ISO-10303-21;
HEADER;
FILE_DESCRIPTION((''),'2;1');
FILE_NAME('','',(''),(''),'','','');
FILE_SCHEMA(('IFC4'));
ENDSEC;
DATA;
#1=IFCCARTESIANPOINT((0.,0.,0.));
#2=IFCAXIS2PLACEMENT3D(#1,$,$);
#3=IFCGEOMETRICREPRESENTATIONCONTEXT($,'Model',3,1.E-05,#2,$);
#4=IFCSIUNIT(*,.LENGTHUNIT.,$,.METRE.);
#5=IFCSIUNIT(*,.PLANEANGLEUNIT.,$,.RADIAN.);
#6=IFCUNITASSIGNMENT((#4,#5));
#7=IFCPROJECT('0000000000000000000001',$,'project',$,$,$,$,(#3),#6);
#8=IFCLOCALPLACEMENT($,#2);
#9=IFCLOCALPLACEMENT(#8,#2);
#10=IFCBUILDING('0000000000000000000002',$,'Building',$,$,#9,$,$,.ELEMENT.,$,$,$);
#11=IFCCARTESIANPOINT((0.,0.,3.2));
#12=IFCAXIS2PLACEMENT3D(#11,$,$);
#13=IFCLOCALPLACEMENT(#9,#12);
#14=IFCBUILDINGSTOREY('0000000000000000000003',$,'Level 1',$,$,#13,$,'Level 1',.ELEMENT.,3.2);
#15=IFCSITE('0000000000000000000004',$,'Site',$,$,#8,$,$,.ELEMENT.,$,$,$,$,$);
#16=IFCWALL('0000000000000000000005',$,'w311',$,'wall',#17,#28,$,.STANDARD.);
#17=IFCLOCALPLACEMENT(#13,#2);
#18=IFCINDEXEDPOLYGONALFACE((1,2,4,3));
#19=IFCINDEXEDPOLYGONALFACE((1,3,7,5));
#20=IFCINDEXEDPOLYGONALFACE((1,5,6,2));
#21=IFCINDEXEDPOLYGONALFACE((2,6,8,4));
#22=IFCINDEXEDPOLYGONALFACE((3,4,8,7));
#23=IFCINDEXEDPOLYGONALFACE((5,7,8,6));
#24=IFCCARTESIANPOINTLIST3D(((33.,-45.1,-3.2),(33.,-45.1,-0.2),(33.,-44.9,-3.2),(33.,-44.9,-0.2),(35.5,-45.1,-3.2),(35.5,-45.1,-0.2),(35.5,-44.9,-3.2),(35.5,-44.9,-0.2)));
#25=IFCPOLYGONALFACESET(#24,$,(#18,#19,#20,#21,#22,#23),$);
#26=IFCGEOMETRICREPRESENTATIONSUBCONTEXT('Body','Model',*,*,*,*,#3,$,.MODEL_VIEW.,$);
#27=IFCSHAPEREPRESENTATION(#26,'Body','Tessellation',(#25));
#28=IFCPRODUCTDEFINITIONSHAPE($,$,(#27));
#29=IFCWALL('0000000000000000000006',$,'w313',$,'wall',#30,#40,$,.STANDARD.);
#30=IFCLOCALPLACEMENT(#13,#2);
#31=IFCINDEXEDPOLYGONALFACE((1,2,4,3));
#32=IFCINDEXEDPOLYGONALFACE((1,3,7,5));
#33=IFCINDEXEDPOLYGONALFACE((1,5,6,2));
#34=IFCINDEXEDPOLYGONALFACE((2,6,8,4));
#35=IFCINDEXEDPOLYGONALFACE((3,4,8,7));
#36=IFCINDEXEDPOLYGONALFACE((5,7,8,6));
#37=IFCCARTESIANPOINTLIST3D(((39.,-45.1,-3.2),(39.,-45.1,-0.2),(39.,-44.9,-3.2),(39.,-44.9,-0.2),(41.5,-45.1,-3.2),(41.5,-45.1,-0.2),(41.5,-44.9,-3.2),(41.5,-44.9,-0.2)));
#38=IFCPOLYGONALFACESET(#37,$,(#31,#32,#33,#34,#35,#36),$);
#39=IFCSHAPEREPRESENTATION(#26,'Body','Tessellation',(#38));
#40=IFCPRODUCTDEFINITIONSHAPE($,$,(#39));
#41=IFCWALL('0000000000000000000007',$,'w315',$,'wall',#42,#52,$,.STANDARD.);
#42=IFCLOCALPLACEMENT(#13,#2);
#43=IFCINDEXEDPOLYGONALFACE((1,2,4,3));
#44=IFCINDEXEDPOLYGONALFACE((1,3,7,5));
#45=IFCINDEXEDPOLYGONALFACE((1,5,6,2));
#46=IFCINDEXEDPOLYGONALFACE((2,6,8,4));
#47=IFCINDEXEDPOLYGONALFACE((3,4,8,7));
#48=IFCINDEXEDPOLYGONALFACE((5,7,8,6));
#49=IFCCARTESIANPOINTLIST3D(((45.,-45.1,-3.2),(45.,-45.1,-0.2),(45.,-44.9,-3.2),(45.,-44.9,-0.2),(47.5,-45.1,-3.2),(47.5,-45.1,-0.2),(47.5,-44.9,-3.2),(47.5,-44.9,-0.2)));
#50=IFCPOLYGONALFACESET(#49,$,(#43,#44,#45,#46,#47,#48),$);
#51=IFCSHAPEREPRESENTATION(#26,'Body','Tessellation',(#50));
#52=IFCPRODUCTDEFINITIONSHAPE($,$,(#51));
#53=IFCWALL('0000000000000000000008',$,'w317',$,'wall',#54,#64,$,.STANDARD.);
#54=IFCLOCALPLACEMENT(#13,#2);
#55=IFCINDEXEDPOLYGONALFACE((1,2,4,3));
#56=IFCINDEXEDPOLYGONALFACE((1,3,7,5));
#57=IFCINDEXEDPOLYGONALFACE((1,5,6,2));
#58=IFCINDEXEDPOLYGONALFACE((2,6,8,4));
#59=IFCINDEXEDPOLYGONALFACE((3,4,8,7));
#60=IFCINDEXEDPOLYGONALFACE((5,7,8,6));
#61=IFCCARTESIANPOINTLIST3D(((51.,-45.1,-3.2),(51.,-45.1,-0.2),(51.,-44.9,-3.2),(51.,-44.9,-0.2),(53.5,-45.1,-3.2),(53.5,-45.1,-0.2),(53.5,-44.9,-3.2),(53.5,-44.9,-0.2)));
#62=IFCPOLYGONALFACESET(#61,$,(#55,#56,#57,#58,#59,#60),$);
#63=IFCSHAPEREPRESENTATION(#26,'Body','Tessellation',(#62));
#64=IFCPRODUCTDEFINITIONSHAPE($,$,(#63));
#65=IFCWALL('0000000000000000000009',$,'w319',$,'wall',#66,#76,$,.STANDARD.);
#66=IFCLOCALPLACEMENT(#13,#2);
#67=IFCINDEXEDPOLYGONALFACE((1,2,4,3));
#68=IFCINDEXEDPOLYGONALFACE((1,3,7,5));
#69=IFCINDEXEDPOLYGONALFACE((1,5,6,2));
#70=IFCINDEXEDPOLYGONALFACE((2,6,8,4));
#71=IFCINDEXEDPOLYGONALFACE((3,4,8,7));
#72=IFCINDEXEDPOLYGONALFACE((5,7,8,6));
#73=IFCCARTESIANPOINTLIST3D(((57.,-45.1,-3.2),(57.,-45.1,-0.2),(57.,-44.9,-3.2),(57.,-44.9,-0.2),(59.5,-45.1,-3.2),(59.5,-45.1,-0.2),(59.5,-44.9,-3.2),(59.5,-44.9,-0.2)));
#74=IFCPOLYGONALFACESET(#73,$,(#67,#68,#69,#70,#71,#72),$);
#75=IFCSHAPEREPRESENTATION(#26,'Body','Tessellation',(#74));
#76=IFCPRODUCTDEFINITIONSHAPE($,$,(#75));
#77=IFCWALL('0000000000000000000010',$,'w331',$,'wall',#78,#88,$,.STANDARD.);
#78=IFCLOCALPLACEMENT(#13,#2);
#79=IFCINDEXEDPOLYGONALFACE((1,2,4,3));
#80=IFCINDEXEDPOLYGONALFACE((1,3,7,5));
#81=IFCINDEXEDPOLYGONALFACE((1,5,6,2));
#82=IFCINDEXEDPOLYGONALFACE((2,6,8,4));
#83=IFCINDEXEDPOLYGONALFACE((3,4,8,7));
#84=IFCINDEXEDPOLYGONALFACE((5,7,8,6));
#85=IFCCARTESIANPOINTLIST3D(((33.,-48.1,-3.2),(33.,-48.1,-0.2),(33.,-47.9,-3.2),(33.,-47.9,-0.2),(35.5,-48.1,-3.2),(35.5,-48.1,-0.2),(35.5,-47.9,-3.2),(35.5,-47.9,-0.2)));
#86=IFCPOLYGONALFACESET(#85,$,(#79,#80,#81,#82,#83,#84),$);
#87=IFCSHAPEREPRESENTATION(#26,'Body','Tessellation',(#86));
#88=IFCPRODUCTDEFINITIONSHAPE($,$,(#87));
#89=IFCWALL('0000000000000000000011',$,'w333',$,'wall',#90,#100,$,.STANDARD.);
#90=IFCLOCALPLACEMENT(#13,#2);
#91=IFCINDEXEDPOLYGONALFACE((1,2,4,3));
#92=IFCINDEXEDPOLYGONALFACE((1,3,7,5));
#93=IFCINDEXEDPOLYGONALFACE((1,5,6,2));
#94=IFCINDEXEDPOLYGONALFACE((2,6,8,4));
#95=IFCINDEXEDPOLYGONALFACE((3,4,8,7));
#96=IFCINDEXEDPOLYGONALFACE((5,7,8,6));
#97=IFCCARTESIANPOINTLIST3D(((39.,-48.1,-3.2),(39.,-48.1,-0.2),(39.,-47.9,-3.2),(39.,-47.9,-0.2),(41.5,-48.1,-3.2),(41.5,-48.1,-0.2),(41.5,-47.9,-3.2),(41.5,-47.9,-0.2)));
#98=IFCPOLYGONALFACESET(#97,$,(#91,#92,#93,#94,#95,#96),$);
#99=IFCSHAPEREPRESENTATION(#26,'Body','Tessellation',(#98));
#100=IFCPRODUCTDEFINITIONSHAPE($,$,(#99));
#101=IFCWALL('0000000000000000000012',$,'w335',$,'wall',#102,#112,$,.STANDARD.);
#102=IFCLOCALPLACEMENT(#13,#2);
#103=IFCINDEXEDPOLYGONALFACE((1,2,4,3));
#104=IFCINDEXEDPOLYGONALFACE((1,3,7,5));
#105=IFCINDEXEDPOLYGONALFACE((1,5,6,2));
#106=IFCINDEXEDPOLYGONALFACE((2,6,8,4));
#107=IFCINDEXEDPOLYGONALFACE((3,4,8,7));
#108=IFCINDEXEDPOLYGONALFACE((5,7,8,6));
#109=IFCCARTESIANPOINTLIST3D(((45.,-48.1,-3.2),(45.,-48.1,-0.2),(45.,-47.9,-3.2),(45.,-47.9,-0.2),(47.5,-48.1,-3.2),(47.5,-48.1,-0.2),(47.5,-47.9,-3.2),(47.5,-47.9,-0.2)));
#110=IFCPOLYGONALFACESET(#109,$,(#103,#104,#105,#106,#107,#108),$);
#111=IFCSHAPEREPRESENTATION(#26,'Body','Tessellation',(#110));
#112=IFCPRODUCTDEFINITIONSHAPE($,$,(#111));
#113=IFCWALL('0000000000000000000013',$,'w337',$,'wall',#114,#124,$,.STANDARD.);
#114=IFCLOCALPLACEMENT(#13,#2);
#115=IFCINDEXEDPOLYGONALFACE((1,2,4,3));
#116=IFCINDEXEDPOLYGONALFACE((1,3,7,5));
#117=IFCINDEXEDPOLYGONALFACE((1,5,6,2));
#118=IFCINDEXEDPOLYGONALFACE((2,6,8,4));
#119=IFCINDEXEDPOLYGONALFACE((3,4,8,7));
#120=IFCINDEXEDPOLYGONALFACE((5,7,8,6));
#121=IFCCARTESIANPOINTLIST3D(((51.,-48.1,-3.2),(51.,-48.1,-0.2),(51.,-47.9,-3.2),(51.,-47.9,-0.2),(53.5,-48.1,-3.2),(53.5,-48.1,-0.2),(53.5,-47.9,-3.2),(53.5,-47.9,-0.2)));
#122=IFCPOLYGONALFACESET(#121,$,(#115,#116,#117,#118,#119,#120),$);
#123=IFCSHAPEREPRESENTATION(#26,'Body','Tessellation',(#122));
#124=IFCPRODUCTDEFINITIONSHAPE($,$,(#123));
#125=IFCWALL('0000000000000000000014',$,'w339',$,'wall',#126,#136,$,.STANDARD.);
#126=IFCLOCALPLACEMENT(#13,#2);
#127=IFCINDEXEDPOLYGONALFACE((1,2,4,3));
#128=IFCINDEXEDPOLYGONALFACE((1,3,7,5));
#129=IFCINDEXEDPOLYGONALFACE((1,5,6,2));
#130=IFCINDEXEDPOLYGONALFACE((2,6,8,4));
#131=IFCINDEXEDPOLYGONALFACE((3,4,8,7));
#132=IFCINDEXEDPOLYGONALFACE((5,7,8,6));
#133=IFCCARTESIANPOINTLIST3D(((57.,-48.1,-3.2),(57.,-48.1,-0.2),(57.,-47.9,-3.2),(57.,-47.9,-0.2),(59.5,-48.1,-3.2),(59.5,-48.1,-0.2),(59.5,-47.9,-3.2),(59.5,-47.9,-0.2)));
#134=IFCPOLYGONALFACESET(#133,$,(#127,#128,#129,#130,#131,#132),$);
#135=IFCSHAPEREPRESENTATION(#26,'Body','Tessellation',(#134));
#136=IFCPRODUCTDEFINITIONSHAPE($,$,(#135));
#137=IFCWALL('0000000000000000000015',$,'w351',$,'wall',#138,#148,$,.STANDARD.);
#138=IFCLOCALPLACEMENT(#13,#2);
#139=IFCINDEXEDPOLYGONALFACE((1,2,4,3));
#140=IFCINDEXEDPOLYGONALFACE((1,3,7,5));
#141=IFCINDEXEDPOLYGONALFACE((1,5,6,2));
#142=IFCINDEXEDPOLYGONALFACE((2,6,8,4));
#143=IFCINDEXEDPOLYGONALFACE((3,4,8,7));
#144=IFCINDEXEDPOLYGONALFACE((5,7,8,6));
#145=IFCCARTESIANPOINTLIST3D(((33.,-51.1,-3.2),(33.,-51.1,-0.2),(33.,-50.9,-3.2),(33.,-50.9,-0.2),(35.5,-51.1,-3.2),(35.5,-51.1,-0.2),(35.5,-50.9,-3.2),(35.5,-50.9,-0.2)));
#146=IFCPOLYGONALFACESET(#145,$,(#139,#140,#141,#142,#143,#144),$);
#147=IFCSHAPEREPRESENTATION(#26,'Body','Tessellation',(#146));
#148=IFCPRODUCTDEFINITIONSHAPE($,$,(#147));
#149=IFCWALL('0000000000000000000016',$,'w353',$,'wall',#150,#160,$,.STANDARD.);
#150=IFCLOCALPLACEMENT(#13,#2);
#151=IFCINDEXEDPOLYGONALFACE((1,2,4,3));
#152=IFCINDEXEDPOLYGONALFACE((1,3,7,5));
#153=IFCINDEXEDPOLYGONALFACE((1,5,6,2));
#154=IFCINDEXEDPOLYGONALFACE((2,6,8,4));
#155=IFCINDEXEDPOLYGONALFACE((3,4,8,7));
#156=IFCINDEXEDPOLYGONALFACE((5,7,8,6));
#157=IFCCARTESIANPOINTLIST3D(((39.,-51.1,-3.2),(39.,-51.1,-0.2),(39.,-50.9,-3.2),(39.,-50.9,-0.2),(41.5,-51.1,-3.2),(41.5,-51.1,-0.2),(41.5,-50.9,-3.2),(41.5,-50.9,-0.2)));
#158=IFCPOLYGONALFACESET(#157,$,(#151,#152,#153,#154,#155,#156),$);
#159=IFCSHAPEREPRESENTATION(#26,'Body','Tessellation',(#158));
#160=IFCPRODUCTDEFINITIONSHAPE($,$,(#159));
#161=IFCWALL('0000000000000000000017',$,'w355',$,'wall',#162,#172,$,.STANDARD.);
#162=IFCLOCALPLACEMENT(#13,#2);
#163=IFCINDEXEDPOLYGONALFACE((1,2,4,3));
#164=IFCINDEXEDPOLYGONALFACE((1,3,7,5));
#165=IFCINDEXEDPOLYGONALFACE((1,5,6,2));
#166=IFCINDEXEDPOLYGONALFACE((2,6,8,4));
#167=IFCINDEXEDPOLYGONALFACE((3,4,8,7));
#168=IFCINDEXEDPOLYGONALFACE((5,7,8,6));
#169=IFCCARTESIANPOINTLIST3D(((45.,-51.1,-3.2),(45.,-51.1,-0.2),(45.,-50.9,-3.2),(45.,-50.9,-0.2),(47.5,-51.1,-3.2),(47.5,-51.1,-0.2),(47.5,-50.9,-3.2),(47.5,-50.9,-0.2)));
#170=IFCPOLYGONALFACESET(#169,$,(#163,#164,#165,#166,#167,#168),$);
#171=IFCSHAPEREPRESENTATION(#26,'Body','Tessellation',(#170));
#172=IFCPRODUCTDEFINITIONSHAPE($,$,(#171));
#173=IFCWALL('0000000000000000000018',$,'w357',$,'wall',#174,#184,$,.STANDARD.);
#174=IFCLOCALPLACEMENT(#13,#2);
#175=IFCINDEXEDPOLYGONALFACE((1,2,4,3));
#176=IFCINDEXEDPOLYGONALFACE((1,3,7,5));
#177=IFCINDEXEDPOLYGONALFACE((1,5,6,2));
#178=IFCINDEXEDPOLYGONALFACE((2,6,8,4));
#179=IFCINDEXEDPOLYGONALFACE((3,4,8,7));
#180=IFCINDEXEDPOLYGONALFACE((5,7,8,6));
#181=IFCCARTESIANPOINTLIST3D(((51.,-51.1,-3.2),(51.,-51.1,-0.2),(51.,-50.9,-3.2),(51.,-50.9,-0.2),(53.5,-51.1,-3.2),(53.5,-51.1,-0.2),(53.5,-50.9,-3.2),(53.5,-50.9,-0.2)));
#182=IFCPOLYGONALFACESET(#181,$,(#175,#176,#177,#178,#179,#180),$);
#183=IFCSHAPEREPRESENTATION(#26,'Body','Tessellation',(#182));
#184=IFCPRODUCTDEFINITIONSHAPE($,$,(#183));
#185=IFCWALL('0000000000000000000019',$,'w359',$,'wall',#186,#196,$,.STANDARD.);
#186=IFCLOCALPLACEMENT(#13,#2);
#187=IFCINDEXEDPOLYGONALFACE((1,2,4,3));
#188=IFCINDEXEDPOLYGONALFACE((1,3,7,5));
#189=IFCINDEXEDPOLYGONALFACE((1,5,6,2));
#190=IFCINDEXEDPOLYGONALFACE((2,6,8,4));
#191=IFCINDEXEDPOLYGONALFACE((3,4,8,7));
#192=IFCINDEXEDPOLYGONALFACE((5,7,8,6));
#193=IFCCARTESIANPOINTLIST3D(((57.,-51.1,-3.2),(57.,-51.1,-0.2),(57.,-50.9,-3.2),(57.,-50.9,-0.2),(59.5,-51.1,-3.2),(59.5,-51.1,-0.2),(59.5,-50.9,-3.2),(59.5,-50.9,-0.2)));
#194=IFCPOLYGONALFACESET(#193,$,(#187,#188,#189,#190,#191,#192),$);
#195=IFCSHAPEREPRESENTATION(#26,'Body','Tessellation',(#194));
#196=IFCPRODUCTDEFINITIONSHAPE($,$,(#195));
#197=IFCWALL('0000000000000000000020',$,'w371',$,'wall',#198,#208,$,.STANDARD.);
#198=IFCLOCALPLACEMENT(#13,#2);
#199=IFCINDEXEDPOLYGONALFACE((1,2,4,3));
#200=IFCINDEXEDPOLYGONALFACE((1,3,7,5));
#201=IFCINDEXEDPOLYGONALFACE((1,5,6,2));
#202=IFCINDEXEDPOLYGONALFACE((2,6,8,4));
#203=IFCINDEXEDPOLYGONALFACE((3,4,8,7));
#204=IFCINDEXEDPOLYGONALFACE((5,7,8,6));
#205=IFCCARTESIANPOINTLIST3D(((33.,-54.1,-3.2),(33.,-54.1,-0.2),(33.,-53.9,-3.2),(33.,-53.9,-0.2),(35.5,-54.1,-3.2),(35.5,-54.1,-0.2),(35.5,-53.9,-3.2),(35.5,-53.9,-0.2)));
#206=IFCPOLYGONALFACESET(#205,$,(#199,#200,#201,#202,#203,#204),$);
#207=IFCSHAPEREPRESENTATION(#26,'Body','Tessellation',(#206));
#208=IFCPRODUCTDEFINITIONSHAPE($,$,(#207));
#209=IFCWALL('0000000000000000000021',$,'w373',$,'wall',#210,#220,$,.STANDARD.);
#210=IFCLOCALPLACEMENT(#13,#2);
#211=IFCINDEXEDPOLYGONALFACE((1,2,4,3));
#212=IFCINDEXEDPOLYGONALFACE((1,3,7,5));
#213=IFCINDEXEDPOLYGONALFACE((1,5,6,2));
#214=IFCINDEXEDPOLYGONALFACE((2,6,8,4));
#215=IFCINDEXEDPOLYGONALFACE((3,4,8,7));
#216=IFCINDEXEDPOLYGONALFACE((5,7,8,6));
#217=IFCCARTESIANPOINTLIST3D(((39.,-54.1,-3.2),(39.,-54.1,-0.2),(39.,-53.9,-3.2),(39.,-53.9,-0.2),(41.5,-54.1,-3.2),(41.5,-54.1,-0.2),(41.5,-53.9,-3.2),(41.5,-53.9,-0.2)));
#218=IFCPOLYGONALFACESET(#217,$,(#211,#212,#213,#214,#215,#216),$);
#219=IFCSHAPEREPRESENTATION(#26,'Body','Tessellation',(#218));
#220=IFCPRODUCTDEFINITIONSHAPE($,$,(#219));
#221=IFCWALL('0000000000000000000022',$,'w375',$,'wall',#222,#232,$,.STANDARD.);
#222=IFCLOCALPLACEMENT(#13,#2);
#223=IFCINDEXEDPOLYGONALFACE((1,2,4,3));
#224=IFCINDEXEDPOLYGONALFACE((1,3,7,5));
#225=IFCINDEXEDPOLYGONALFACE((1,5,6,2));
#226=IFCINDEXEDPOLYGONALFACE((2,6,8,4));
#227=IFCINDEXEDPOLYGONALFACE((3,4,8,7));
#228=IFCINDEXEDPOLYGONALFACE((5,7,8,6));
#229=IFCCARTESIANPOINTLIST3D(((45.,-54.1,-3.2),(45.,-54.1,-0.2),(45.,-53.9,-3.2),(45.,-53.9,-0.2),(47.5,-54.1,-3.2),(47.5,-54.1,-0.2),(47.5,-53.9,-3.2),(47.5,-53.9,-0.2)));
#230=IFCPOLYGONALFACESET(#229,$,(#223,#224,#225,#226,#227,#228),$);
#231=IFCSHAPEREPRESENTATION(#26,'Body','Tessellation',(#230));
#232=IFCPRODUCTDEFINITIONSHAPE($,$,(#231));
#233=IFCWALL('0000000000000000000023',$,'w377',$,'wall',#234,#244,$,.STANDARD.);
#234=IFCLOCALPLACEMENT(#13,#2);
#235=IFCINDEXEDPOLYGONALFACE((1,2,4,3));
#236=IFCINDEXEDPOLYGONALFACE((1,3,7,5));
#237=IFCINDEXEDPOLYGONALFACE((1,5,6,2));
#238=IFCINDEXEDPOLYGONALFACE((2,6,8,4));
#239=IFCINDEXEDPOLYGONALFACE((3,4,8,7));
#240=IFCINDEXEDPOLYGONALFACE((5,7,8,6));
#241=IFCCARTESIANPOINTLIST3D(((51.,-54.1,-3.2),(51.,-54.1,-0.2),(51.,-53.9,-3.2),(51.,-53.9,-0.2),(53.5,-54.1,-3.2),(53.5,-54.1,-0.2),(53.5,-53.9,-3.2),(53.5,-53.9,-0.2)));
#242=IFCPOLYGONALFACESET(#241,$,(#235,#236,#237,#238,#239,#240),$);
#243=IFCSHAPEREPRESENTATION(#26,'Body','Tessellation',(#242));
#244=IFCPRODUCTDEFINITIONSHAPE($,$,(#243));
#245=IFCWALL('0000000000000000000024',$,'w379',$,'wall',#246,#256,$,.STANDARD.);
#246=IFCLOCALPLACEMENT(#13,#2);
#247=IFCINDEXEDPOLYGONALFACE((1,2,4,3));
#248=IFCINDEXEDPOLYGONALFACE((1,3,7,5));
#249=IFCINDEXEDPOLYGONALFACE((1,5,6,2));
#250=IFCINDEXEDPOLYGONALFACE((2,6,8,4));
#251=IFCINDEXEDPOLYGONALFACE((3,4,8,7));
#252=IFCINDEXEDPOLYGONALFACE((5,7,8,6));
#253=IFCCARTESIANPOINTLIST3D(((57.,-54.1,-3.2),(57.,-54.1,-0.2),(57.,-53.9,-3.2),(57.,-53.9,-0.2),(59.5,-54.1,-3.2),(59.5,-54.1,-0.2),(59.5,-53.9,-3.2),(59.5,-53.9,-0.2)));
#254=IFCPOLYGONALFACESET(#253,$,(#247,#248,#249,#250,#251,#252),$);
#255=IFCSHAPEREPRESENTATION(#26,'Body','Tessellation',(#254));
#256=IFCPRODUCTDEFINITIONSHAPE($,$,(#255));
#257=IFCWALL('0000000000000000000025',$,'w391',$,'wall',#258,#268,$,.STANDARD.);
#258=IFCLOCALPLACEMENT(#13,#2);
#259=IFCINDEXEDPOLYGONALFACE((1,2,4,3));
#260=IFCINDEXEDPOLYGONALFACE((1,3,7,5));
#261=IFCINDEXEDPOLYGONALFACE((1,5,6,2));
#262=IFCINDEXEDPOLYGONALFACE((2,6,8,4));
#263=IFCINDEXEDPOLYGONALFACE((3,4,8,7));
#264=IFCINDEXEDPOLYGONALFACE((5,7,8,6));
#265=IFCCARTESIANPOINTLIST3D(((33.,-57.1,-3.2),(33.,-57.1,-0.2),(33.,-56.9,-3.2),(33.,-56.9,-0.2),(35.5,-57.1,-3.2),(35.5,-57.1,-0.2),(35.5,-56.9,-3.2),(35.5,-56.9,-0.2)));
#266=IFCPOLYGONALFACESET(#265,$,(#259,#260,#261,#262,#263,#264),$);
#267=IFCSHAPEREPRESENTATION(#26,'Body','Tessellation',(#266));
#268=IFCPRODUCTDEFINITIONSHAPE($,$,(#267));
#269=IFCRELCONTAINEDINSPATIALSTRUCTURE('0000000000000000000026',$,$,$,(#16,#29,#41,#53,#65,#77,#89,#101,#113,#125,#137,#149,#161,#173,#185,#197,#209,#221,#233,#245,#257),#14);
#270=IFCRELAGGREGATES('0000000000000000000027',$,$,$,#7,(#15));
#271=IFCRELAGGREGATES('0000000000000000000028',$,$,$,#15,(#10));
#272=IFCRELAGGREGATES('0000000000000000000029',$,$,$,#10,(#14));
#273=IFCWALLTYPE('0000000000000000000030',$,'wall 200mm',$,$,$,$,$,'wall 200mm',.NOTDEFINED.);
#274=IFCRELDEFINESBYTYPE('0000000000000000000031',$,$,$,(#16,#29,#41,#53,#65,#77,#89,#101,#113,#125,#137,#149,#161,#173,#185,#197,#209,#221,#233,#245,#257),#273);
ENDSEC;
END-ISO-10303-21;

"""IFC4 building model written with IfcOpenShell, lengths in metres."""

from ifc_helpers import new_model, si_unit, frame, frame_2d, origin, place, context, subcontext, project, spatial, rectangle, extrude, type_object, element, save


model = new_model("IFC4")

# Units and contexts
model_context = context("Model", 3, precision=1e-05, world=origin())
body_context = subcontext(model_context, "Body", "Model", "MODEL_VIEW")
ifc_project = project(units=[si_unit("LENGTHUNIT", "METRE"), si_unit("PLANEANGLEUNIT", "RADIAN")], contexts=[model_context])

# Site, building, storey
site_placement = place(None, origin())
site = spatial("IfcSite", under=ifc_project, at=site_placement, Name="Site", CompositionType="ELEMENT")
building_placement = place(site_placement, origin())
building = spatial("IfcBuilding", under=site, at=building_placement, Name="Building", CompositionType="ELEMENT")
storey_placement = place(building_placement, frame((0.0, 0.0, 3.2)))
storey = spatial("IfcBuildingStorey", under=building, at=storey_placement, Name="Level 1", LongName="Level 1", CompositionType="ELEMENT", Elevation=3.2)

# Walls
wall_type = type_object("IfcWallType", Name="wall 200mm", ElementType="wall 200mm", PredefinedType="NOTDEFINED")
for number, where, z_axis, x_axis, name in (
    (1, (33.0, -45.0, -3.2), (0.0, 0.0, 1.0), (1.0, 0.0, 0.0), "w311"),
    (2, (39.0, -45.0, -3.2), (0.0, 0.0, 1.0), (1.0, 0.0, 0.0), "w313"),
    (3, (45.0, -45.0, -3.2), (0.0, 0.0, 1.0), (1.0, 0.0, 0.0), "w315"),
    (4, (51.0, -45.0, -3.2), (0.0, 0.0, 1.0), (1.0, 0.0, 0.0), "w317"),
    (5, (57.0, -45.0, -3.2), (0.0, 0.0, 1.0), (1.0, 0.0, 0.0), "w319"),
    (6, (33.0, -48.0, -3.2), (0.0, 0.0, 1.0), (1.0, 0.0, 0.0), "w331"),
    (7, (39.0, -48.0, -3.2), (0.0, 0.0, 1.0), (1.0, 0.0, 0.0), "w333"),
    (8, (45.0, -48.0, -3.2), (0.0, 0.0, 1.0), (1.0, 0.0, 0.0), "w335"),
    (9, (51.0, -48.0, -3.2), (0.0, 0.0, 1.0), (1.0, 0.0, 0.0), "w337"),
    (10, (57.0, -48.0, -3.2), (0.0, 0.0, 1.0), (1.0, 0.0, 0.0), "w339"),
    (11, (33.0, -51.0, -3.2), (0.0, 0.0, 1.0), (1.0, 0.0, 0.0), "w351"),
    (12, (39.0, -51.0, -3.2), (0.0, 0.0, 1.0), (1.0, 0.0, 0.0), "w353"),
    (13, (45.0, -51.0, -3.2), (0.0, 0.0, 1.0), (1.0, 0.0, 0.0), "w355"),
    (14, (51.0, -51.0, -3.2), (0.0, 0.0, 1.0), (1.0, 0.0, 0.0), "w357"),
    (15, (57.0, -51.0, -3.2), (0.0, 0.0, 1.0), (1.0, 0.0, 0.0), "w359"),
    (16, (33.0, -54.0, -3.2), (0.0, 0.0, 1.0), (1.0, 0.0, 0.0), "w371"),
    (17, (39.0, -54.0, -3.2), (0.0, 0.0, 1.0), (1.0, 0.0, 0.0), "w373"),
    (18, (45.0, -54.0, -3.2), (0.0, 0.0, 1.0), (1.0, 0.0, 0.0), "w375"),
    (19, (51.0, -54.0, -3.2), (0.0, 0.0, 1.0), (1.0, 0.0, 0.0), "w377"),
    (20, (57.0, -54.0, -3.2), (0.0, 0.0, 1.0), (1.0, 0.0, 0.0), "w379"),
    (21, (33.0, -57.0, -3.2), (0.0, 0.0, 1.0), (1.0, 0.0, 0.0), "w391"),
):
    element("IfcWall", number, at=place(storey_placement, frame(where, z_axis=z_axis, x_axis=x_axis)), inside=storey, type_object=wall_type, Name=name, ObjectType="wall", PredefinedType="STANDARD", context=body_context, shape_type="SweptSolid", body=[
        extrude(rectangle(XDim=2.5, YDim=0.2, at=frame_2d((1.25, 0.0))), origin(), (0.0, 0.0, 1.0), 3.0),
    ])

save(model, "model.ifc")
